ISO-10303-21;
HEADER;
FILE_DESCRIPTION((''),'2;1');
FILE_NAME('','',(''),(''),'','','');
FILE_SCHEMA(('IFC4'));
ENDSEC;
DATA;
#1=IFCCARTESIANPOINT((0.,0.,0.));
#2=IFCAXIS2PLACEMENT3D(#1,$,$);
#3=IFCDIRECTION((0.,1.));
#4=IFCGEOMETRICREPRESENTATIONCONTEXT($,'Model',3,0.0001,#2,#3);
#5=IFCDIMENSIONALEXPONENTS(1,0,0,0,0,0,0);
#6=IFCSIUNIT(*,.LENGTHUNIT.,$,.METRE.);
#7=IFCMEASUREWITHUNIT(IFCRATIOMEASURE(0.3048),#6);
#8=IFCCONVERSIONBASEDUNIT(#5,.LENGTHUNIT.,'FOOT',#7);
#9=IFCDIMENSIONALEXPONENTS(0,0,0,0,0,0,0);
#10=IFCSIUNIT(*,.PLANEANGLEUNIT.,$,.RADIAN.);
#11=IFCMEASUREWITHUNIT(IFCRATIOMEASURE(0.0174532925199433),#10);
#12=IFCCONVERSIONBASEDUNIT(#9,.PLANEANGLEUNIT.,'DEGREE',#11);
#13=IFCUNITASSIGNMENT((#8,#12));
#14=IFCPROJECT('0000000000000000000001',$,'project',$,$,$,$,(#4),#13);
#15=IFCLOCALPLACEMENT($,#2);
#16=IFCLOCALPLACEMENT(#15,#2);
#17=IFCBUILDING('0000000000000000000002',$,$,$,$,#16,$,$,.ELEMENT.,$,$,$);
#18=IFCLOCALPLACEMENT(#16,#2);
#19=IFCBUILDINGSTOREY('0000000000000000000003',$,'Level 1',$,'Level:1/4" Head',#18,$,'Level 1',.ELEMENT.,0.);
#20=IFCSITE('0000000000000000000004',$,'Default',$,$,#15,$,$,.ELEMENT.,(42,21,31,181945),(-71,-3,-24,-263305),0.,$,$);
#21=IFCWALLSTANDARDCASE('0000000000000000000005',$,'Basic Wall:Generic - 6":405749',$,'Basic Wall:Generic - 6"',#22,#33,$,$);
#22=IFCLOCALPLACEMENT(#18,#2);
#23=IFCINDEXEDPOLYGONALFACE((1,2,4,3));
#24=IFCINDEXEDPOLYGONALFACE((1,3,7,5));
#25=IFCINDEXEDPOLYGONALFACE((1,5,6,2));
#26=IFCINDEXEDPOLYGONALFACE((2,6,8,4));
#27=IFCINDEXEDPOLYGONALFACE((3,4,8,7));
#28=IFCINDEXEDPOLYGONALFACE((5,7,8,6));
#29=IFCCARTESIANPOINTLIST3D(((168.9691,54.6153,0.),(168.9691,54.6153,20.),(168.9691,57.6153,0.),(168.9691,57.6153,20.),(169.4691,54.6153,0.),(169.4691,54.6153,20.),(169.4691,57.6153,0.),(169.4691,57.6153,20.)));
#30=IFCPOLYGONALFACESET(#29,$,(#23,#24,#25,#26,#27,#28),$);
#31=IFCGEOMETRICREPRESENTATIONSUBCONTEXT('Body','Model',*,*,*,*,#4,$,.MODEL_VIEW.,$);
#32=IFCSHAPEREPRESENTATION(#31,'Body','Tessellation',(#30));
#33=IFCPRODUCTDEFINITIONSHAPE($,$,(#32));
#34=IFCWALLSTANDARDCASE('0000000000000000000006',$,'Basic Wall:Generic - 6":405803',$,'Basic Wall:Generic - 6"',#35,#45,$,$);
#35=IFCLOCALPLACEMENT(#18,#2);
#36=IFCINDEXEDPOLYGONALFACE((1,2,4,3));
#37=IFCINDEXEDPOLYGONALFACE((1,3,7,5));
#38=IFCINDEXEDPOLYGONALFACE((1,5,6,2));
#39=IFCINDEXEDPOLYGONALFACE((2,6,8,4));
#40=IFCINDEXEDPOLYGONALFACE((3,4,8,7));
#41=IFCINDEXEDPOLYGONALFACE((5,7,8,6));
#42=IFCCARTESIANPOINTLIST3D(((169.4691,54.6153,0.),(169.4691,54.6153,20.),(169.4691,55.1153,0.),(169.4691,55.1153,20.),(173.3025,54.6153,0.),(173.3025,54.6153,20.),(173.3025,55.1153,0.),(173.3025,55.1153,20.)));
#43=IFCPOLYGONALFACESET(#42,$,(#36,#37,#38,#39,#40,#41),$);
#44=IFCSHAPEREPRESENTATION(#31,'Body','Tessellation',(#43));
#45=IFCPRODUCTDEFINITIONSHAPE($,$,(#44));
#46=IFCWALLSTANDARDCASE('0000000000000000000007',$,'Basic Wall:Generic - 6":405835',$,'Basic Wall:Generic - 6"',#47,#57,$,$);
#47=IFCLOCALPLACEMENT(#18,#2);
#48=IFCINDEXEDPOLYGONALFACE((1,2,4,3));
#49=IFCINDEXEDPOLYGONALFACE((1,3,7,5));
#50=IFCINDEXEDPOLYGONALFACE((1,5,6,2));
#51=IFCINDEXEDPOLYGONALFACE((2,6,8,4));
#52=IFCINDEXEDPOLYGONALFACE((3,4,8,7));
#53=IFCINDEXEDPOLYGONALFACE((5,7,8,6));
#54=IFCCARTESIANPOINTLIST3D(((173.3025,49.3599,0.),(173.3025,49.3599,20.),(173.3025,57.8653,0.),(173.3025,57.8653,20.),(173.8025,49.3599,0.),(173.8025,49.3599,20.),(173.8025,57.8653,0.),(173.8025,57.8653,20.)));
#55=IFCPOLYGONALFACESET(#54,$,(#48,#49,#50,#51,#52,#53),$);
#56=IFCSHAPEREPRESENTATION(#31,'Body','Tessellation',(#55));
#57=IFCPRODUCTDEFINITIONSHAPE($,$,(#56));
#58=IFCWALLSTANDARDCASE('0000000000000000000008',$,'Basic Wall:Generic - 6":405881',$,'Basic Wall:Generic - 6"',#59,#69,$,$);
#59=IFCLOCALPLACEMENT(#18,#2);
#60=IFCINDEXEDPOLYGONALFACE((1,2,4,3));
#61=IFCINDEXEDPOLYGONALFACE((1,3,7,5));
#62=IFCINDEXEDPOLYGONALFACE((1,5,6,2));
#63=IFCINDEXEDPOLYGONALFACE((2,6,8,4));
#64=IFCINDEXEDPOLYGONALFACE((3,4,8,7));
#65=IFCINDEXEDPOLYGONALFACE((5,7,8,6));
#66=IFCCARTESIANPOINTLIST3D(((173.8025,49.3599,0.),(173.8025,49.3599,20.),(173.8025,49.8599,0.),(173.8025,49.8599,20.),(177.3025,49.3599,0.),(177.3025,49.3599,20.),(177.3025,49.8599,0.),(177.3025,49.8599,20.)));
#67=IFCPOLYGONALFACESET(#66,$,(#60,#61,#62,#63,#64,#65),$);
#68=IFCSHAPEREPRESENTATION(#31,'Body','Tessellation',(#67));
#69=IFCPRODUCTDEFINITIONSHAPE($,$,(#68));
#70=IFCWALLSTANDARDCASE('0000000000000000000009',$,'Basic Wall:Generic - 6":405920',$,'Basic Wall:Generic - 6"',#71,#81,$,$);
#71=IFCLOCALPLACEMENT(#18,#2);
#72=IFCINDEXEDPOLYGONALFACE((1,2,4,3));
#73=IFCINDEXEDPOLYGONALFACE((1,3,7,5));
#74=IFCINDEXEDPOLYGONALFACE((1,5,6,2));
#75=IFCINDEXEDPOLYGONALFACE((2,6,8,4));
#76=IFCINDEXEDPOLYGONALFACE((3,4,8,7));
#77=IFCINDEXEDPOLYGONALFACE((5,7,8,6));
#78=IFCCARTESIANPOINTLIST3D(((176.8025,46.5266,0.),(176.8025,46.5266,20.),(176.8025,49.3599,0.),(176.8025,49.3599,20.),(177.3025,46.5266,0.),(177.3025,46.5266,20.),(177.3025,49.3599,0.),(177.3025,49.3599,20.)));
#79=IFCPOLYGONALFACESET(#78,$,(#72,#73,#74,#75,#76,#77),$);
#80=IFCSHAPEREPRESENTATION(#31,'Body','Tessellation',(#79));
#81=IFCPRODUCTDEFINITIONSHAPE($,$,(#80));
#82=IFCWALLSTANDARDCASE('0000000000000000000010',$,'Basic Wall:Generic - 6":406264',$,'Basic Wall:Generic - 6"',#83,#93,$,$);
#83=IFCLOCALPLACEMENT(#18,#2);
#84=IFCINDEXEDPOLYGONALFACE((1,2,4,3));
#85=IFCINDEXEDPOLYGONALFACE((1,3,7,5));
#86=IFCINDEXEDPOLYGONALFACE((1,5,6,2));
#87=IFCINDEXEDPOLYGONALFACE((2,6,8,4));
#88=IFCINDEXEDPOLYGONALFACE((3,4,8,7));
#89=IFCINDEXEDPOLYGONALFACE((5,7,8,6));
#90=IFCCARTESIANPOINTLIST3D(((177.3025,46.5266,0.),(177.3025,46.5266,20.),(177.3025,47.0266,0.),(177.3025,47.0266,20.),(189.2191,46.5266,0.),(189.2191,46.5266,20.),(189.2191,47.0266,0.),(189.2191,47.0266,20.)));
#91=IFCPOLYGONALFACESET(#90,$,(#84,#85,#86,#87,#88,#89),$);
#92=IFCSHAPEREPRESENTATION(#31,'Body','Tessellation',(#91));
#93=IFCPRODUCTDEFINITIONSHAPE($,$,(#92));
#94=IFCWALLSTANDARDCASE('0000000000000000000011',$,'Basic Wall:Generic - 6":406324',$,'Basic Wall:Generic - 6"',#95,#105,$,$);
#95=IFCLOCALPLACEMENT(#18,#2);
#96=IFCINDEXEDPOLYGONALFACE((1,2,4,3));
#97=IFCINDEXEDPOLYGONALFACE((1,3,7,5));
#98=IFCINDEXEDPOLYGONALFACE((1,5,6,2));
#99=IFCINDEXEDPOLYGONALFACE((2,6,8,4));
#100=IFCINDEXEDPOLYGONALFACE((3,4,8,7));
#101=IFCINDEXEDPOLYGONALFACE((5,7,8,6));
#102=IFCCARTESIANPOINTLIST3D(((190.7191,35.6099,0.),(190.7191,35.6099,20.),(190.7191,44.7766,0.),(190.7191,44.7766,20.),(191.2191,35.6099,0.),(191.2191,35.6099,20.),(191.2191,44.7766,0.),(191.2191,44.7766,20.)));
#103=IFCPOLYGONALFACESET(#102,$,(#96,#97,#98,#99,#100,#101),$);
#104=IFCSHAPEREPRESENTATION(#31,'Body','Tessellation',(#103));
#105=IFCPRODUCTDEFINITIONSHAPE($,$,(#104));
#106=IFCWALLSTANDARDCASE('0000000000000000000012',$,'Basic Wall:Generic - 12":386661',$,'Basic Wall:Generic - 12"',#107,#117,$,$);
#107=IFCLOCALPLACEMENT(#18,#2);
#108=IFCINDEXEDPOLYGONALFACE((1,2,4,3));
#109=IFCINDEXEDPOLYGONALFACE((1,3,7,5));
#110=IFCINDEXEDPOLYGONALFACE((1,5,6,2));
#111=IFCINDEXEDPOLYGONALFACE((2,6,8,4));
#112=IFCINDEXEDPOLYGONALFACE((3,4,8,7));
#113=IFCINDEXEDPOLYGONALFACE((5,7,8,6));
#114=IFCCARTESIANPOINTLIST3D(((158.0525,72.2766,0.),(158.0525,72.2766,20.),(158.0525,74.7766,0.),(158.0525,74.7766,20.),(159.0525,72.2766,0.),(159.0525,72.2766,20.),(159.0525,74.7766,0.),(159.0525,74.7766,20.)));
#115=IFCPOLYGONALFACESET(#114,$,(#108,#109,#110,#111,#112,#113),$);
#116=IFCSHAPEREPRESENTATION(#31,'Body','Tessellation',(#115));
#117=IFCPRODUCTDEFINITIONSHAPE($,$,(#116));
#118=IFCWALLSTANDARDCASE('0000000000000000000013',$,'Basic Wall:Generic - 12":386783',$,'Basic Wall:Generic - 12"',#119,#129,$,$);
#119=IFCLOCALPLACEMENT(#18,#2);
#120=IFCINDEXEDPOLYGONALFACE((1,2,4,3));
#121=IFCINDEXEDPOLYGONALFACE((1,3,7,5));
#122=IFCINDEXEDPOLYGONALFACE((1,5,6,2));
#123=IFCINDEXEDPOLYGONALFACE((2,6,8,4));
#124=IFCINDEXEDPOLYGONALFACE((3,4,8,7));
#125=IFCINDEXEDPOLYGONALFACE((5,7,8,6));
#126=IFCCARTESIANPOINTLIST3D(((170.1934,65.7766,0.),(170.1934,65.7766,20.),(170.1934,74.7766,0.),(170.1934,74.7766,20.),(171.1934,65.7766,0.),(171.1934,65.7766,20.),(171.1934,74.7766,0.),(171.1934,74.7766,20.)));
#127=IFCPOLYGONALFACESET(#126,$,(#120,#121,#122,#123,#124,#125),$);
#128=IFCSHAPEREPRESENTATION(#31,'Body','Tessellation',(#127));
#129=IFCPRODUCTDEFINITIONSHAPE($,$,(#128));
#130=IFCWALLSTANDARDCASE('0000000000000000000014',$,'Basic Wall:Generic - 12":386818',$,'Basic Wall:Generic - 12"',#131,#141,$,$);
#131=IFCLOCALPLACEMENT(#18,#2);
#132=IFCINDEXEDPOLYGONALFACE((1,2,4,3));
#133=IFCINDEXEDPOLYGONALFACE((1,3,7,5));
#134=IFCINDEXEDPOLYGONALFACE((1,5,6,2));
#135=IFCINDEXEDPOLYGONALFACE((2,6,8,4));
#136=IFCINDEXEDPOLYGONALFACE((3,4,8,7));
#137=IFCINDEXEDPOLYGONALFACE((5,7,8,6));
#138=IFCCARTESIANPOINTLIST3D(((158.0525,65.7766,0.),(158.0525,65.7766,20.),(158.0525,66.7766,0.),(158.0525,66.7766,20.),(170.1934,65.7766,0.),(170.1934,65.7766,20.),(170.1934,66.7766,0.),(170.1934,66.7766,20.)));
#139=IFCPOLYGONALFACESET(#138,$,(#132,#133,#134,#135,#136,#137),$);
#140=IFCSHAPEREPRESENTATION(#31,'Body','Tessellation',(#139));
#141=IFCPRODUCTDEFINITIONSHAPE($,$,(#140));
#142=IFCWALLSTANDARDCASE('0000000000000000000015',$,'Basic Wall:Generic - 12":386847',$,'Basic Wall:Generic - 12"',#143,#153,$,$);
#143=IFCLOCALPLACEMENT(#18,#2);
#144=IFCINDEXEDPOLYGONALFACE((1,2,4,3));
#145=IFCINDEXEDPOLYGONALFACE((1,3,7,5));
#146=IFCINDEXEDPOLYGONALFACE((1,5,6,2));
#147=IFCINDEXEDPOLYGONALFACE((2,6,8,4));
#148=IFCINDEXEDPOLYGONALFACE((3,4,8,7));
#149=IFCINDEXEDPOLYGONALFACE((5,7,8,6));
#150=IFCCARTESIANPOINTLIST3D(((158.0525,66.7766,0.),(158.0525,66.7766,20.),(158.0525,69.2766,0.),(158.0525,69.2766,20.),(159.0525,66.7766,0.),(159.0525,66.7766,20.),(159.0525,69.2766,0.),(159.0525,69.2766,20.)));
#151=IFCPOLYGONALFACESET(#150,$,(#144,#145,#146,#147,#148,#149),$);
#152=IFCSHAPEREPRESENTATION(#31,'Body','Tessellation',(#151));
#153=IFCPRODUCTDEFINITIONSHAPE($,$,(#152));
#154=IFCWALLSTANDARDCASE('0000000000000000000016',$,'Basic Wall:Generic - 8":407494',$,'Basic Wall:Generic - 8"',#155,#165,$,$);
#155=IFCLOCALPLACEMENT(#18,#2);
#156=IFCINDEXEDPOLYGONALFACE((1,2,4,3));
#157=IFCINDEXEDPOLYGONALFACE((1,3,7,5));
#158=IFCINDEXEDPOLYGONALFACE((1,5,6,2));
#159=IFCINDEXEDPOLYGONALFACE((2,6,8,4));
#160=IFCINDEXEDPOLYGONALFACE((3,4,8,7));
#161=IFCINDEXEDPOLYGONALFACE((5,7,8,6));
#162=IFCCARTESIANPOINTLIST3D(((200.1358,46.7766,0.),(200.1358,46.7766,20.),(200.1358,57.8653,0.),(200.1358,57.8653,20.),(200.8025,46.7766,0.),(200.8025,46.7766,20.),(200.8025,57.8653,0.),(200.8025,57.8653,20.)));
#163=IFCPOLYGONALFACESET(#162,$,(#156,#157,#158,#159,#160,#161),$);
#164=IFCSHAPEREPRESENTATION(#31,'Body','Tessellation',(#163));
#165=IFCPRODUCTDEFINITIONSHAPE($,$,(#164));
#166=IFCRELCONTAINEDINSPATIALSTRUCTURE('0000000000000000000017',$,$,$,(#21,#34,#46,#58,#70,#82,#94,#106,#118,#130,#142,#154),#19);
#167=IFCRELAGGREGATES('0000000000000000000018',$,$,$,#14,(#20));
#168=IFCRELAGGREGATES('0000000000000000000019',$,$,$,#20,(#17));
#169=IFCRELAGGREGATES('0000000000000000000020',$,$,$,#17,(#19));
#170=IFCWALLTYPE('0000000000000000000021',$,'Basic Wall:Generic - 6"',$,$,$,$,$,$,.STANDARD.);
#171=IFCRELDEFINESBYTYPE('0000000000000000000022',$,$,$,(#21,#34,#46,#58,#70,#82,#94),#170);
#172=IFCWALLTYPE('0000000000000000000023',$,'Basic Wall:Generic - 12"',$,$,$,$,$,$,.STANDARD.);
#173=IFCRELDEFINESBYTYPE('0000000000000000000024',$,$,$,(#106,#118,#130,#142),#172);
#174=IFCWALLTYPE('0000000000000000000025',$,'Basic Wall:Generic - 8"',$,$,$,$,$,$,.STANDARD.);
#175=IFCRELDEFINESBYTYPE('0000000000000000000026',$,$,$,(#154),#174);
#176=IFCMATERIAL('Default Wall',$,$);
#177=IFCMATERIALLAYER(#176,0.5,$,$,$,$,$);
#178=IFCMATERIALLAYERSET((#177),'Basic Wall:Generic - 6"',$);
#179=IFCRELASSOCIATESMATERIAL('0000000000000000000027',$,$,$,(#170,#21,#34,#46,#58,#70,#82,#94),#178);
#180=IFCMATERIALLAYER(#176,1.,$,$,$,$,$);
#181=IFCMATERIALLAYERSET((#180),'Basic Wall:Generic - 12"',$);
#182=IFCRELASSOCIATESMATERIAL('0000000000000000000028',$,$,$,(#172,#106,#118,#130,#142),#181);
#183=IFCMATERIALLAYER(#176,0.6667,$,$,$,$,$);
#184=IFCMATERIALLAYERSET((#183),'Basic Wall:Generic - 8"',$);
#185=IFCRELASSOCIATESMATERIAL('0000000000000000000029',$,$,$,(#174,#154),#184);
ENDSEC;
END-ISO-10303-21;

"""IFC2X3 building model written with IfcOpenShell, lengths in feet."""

from ifc_helpers import new_model, entity, si_unit, converted_unit, direction, frame, frame_2d, origin, place, context, subcontext, project, spatial, rectangle, extrude, material, layer, layer_set, layer_usage, type_object, element, save


model = new_model("IFC2X3")

# Units and contexts
model_context = context("Model", 3, precision=0.0001, world=origin(), true_north=direction((0.0, 1.0)))
body_context = subcontext(model_context, "Body", "Model", "MODEL_VIEW")
ifc_project = project(units=[converted_unit("LENGTHUNIT", "FOOT", entity("IfcRatioMeasure", 0.3048), si_unit("LENGTHUNIT", "METRE"), dimensions=[1, 0, 0, 0, 0, 0, 0]), converted_unit("PLANEANGLEUNIT", "DEGREE", entity("IfcRatioMeasure", 0.0174532925199433), si_unit("PLANEANGLEUNIT", "RADIAN"), dimensions=[0, 0, 0, 0, 0, 0, 0])], contexts=[model_context])

# Site, building, storey
site_placement = place(None, origin())
site = spatial("IfcSite", under=ifc_project, at=site_placement, Name="Default", CompositionType="ELEMENT", RefLatitude=(42, 21, 31, 181945), RefLongitude=(-71, -3, -24, -263305), RefElevation=0.0)
building_placement = place(site_placement, origin())
building = spatial("IfcBuilding", under=site, at=building_placement, CompositionType="ELEMENT")
storey_placement = place(building_placement, origin())
storey = spatial("IfcBuildingStorey", under=building, at=storey_placement, Name="Level 1", ObjectType="Level:1/4\" Head", LongName="Level 1", CompositionType="ELEMENT", Elevation=0.0)

# Walls
ifc_material = material(Name="Default Wall")
ifc_layer_1 = layer(ifc_material, 0.5)
ifc_layer_set_1 = layer_set([ifc_layer_1], Name="Basic Wall:Generic - 6\"")
wall_type_1 = type_object("IfcWallType", Name="Basic Wall:Generic - 6\"", PredefinedType="STANDARD", material=ifc_layer_set_1)
ifc_layer_usage_1 = layer_usage(ifc_layer_set_1, "AXIS2", "NEGATIVE", 0.25)
wall_1_placement = place(storey_placement, frame((169.2191, 57.6153, 0.0), z_axis=(0.0, 0.0, 1.0), x_axis=(0.0, -1.0, 0.0)))
element("IfcWallStandardCase", 1, at=wall_1_placement, inside=storey, type_object=wall_type_1, material=ifc_layer_usage_1, Name="Basic Wall:Generic - 6\":405749", ObjectType="Basic Wall:Generic - 6\"", context=body_context, shape_type="SweptSolid", body=[
    extrude(rectangle(XDim=3.0, YDim=0.5, at=frame_2d((1.5, 0.0), x_axis=(-1.0, 0.0))), origin(), (0.0, 0.0, 1.0), 20.0),
])
ifc_layer_usage_2 = layer_usage(ifc_layer_set_1, "AXIS2", "NEGATIVE", 0.25)
wall_2_placement = place(storey_placement, frame((169.4691, 54.8653, 0.0)))
element("IfcWallStandardCase", 2, at=wall_2_placement, inside=storey, type_object=wall_type_1, material=ifc_layer_usage_2, Name="Basic Wall:Generic - 6\":405803", ObjectType="Basic Wall:Generic - 6\"", context=body_context, shape_type="SweptSolid", body=[
    extrude(rectangle(XDim=3.8333, YDim=0.5, at=frame_2d((1.9167, 0.0), x_axis=(-1.0, 0.0))), origin(), (0.0, 0.0, 1.0), 20.0),
])
ifc_layer_usage_3 = layer_usage(ifc_layer_set_1, "AXIS2", "NEGATIVE", 0.25)
wall_3_placement = place(storey_placement, frame((173.5525, 57.8653, 0.0), z_axis=(0.0, 0.0, 1.0), x_axis=(0.0, -1.0, 0.0)))
element("IfcWallStandardCase", 3, at=wall_3_placement, inside=storey, type_object=wall_type_1, material=ifc_layer_usage_3, Name="Basic Wall:Generic - 6\":405835", ObjectType="Basic Wall:Generic - 6\"", context=body_context, shape_type="SweptSolid", body=[
    extrude(rectangle(XDim=8.5054, YDim=0.5, at=frame_2d((4.2527, 0.0), x_axis=(-1.0, 0.0))), origin(), (0.0, 0.0, 1.0), 20.0),
])
ifc_layer_usage_4 = layer_usage(ifc_layer_set_1, "AXIS2", "NEGATIVE", 0.25)
wall_4_placement = place(storey_placement, frame((173.8025, 49.6099, 0.0)))
element("IfcWallStandardCase", 4, at=wall_4_placement, inside=storey, type_object=wall_type_1, material=ifc_layer_usage_4, Name="Basic Wall:Generic - 6\":405881", ObjectType="Basic Wall:Generic - 6\"", context=body_context, shape_type="SweptSolid", body=[
    extrude(rectangle(XDim=3.5, YDim=0.5, at=frame_2d((1.75, 0.0), x_axis=(-1.0, 0.0))), origin(), (0.0, 0.0, 1.0), 20.0),
])
ifc_layer_usage_5 = layer_usage(ifc_layer_set_1, "AXIS2", "NEGATIVE", 0.25)
wall_5_placement = place(storey_placement, frame((177.0525, 49.3599, 0.0), z_axis=(0.0, 0.0, 1.0), x_axis=(0.0, -1.0, 0.0)))
element("IfcWallStandardCase", 5, at=wall_5_placement, inside=storey, type_object=wall_type_1, material=ifc_layer_usage_5, Name="Basic Wall:Generic - 6\":405920", ObjectType="Basic Wall:Generic - 6\"", context=body_context, shape_type="SweptSolid", body=[
    extrude(rectangle(XDim=2.8333, YDim=0.5, at=frame_2d((1.4167, 0.0), x_axis=(-1.0, 0.0))), origin(), (0.0, 0.0, 1.0), 20.0),
])
ifc_layer_usage_6 = layer_usage(ifc_layer_set_1, "AXIS2", "NEGATIVE", 0.25)
wall_6_placement = place(storey_placement, frame((189.2191, 46.7766, 0.0), z_axis=(0.0, 0.0, 1.0), x_axis=(-1.0, 0.0, 0.0)))
element("IfcWallStandardCase", 6, at=wall_6_placement, inside=storey, type_object=wall_type_1, material=ifc_layer_usage_6, Name="Basic Wall:Generic - 6\":406264", ObjectType="Basic Wall:Generic - 6\"", context=body_context, shape_type="SweptSolid", body=[
    extrude(rectangle(XDim=11.9167, YDim=0.5, at=frame_2d((5.9583, 0.0), x_axis=(-1.0, 0.0))), origin(), (0.0, 0.0, 1.0), 20.0),
])
ifc_layer_usage_7 = layer_usage(ifc_layer_set_1, "AXIS2", "NEGATIVE", 0.25)
wall_7_placement = place(storey_placement, frame((190.9691, 44.7766, 0.0), z_axis=(0.0, 0.0, 1.0), x_axis=(0.0, -1.0, 0.0)))
element("IfcWallStandardCase", 7, at=wall_7_placement, inside=storey, type_object=wall_type_1, material=ifc_layer_usage_7, Name="Basic Wall:Generic - 6\":406324", ObjectType="Basic Wall:Generic - 6\"", context=body_context, shape_type="SweptSolid", body=[
    extrude(rectangle(XDim=9.1667, YDim=0.5, at=frame_2d((4.5833, 0.0), x_axis=(-1.0, 0.0))), origin(), (0.0, 0.0, 1.0), 20.0),
])
ifc_layer_2 = layer(ifc_material, 1.0)
ifc_layer_set_2 = layer_set([ifc_layer_2], Name="Basic Wall:Generic - 12\"")
ifc_layer_usage_8 = layer_usage(ifc_layer_set_2, "AXIS2", "NEGATIVE", 0.5)
wall_type_2 = type_object("IfcWallType", Name="Basic Wall:Generic - 12\"", PredefinedType="STANDARD", material=ifc_layer_set_2)
wall_8_placement = place(storey_placement, frame((158.5525, 72.2766, 0.0), z_axis=(0.0, 0.0, 1.0), x_axis=(0.0, 1.0, 0.0)))
element("IfcWallStandardCase", 8, at=wall_8_placement, inside=storey, type_object=wall_type_2, material=ifc_layer_usage_8, Name="Basic Wall:Generic - 12\":386661", ObjectType="Basic Wall:Generic - 12\"", context=body_context, shape_type="SweptSolid", body=[
    extrude(rectangle(XDim=2.5, YDim=1.0, at=frame_2d((1.25, 0.0), x_axis=(-1.0, 0.0))), origin(), (0.0, 0.0, 1.0), 20.0),
])
ifc_layer_usage_9 = layer_usage(ifc_layer_set_2, "AXIS2", "NEGATIVE", 0.5)
wall_9_placement = place(storey_placement, frame((170.6934, 74.7766, 0.0), z_axis=(0.0, 0.0, 1.0), x_axis=(0.0, -1.0, 0.0)))
element("IfcWallStandardCase", 9, at=wall_9_placement, inside=storey, type_object=wall_type_2, material=ifc_layer_usage_9, Name="Basic Wall:Generic - 12\":386783", ObjectType="Basic Wall:Generic - 12\"", context=body_context, shape_type="SweptSolid", body=[
    extrude(rectangle(XDim=9.0, YDim=1.0, at=frame_2d((4.5, 0.0), x_axis=(-1.0, 0.0))), origin(), (0.0, 0.0, 1.0), 20.0),
])
ifc_layer_usage_10 = layer_usage(ifc_layer_set_2, "AXIS2", "NEGATIVE", 0.5)
wall_10_placement = place(storey_placement, frame((170.1934, 66.2766, 0.0), z_axis=(0.0, 0.0, 1.0), x_axis=(-1.0, 0.0, 0.0)))
element("IfcWallStandardCase", 10, at=wall_10_placement, inside=storey, type_object=wall_type_2, material=ifc_layer_usage_10, Name="Basic Wall:Generic - 12\":386818", ObjectType="Basic Wall:Generic - 12\"", context=body_context, shape_type="SweptSolid", body=[
    extrude(rectangle(XDim=12.141, YDim=1.0, at=frame_2d((6.0705, 0.0), x_axis=(-1.0, 0.0))), origin(), (0.0, 0.0, 1.0), 20.0),
])
ifc_layer_usage_11 = layer_usage(ifc_layer_set_2, "AXIS2", "NEGATIVE", 0.5)
wall_11_placement = place(storey_placement, frame((158.5525, 66.7766, 0.0), z_axis=(0.0, 0.0, 1.0), x_axis=(0.0, 1.0, 0.0)))
element("IfcWallStandardCase", 11, at=wall_11_placement, inside=storey, type_object=wall_type_2, material=ifc_layer_usage_11, Name="Basic Wall:Generic - 12\":386847", ObjectType="Basic Wall:Generic - 12\"", context=body_context, shape_type="SweptSolid", body=[
    extrude(rectangle(XDim=2.5, YDim=1.0, at=frame_2d((1.25, 0.0), x_axis=(-1.0, 0.0))), origin(), (0.0, 0.0, 1.0), 20.0),
])
ifc_layer_3 = layer(ifc_material, 0.6667)
ifc_layer_set_3 = layer_set([ifc_layer_3], Name="Basic Wall:Generic - 8\"")
ifc_layer_usage_12 = layer_usage(ifc_layer_set_3, "AXIS2", "NEGATIVE", 0.3333)
wall_type_3 = type_object("IfcWallType", Name="Basic Wall:Generic - 8\"", PredefinedType="STANDARD", material=ifc_layer_set_3)
wall_12_placement = place(storey_placement, frame((200.4691, 46.7766, 0.0), z_axis=(0.0, 0.0, 1.0), x_axis=(0.0, 1.0, 0.0)))
element("IfcWallStandardCase", 12, at=wall_12_placement, inside=storey, type_object=wall_type_3, material=ifc_layer_usage_12, Name="Basic Wall:Generic - 8\":407494", ObjectType="Basic Wall:Generic - 8\"", context=body_context, shape_type="SweptSolid", body=[
    extrude(rectangle(XDim=11.0887, YDim=0.6667, at=frame_2d((5.5444, 0.0), x_axis=(-1.0, 0.0))), origin(), (0.0, 0.0, 1.0), 20.0),
])

save(model, "model.ifc")
